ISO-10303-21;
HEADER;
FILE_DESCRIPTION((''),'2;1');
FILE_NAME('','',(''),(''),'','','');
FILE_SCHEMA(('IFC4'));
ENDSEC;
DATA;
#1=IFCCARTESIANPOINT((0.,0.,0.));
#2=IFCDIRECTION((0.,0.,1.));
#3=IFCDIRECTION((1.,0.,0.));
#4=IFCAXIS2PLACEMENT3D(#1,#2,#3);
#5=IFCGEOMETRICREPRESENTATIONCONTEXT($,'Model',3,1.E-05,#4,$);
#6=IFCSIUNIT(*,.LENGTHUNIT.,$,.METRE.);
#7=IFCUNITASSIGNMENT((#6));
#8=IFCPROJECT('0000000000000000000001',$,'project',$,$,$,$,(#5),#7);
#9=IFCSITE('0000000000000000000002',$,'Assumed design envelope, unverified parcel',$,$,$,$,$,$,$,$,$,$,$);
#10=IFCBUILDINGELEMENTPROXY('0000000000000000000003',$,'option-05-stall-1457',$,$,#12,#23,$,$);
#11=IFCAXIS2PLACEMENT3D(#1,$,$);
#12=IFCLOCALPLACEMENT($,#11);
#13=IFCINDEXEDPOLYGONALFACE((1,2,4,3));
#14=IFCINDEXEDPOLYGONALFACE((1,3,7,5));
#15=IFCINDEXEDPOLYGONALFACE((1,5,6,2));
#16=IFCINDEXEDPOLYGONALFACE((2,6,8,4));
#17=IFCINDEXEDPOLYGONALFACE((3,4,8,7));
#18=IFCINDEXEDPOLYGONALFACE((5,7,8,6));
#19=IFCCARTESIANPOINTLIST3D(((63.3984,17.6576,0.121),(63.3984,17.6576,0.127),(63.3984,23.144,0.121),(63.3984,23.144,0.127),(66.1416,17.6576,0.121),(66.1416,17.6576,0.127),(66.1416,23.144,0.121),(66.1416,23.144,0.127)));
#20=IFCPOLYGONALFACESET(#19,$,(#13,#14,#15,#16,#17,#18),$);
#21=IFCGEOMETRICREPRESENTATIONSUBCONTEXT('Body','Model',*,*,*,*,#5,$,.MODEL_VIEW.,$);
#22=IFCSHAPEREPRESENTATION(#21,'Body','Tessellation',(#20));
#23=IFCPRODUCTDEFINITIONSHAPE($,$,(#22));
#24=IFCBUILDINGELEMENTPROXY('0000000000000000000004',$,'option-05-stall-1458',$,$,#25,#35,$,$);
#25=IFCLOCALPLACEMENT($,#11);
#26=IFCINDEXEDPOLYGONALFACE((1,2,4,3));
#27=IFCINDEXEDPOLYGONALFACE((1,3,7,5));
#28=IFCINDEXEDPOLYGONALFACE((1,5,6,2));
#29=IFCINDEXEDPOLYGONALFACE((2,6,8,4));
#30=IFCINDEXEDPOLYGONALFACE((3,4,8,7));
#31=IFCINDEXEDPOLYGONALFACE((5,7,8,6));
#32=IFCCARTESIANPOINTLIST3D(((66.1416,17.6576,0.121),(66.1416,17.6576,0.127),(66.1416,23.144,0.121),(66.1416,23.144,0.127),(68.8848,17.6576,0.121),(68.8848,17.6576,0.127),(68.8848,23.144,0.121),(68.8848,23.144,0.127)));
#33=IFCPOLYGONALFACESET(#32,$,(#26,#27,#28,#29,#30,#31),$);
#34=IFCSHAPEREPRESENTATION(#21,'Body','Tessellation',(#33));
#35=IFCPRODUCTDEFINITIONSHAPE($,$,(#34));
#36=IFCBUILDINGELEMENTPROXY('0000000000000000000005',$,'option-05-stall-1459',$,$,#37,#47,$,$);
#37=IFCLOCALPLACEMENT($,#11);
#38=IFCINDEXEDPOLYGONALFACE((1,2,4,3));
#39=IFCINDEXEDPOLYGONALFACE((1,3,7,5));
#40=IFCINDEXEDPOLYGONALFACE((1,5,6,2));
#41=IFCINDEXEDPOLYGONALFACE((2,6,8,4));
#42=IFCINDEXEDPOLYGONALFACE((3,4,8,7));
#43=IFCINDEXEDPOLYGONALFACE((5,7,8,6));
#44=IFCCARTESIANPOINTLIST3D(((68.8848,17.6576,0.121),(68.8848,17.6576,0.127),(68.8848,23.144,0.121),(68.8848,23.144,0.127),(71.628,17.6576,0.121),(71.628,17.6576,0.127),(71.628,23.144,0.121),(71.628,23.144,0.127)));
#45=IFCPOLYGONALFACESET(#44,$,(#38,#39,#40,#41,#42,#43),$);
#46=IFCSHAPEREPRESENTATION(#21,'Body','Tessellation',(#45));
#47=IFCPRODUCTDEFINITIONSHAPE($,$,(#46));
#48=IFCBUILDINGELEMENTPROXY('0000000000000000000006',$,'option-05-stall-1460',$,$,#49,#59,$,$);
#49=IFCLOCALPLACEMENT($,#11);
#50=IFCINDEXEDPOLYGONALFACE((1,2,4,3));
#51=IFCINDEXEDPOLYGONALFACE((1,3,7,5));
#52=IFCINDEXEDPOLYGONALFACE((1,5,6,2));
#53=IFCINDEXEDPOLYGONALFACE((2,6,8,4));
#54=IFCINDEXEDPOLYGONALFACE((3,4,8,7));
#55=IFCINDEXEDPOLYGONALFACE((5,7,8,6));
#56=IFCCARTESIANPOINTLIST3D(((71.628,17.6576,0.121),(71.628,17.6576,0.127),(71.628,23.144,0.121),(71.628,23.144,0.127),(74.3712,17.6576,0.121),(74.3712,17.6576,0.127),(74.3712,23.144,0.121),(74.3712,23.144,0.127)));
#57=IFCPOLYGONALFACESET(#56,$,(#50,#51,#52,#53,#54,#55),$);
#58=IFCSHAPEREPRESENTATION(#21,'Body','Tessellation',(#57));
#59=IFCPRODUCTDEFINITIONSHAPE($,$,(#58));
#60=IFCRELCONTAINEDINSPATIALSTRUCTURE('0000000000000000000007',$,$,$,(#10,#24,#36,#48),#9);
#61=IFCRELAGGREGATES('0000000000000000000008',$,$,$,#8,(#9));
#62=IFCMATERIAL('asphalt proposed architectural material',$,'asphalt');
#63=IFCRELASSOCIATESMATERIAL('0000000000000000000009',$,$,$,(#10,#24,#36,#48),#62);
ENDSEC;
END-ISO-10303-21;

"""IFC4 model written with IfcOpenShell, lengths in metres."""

from ifc_helpers import new_model, si_unit, frame, origin_with_axes, place, context, subcontext, project, spatial, rectangle, extrude, material, element, save


model = new_model("IFC4")

# Units and contexts
model_context = context("Model", 3, precision=1e-05, world=origin_with_axes())
body_context = subcontext(model_context, "Body", "Model", "MODEL_VIEW")
ifc_project = project(units=[si_unit("LENGTHUNIT", "METRE")], contexts=[model_context])

# Site
site = spatial("IfcSite", under=ifc_project, Name="Assumed design envelope, unverified parcel")

# Building element proxies
ifc_material = material(Name="asphalt proposed architectural material", Category="asphalt")
for number, where, z_axis, x_axis, name in (
    (1, (64.77, 20.4008, 0.121), (0.0, 0.0, 1.0), (1.0, 0.0, 0.0), "option-05-stall-1457"),
    (2, (67.5132, 20.4008, 0.121), (0.0, 0.0, 1.0), (1.0, 0.0, 0.0), "option-05-stall-1458"),
    (3, (70.2564, 20.4008, 0.121), (0.0, 0.0, 1.0), (1.0, 0.0, 0.0), "option-05-stall-1459"),
    (4, (72.9996, 20.4008, 0.121), (0.0, 0.0, 1.0), (1.0, 0.0, 0.0), "option-05-stall-1460"),
):
    element("IfcBuildingElementProxy", number, at=place(None, frame(where, z_axis=z_axis, x_axis=x_axis)), inside=site, material=ifc_material, Name=name, context=body_context, shape_type="SweptSolid", body=[
        extrude(rectangle(XDim=2.7432, YDim=5.4864), origin_with_axes(), (0.0, 0.0, 1.0), 0.006),
    ])

save(model, "model.ifc")
